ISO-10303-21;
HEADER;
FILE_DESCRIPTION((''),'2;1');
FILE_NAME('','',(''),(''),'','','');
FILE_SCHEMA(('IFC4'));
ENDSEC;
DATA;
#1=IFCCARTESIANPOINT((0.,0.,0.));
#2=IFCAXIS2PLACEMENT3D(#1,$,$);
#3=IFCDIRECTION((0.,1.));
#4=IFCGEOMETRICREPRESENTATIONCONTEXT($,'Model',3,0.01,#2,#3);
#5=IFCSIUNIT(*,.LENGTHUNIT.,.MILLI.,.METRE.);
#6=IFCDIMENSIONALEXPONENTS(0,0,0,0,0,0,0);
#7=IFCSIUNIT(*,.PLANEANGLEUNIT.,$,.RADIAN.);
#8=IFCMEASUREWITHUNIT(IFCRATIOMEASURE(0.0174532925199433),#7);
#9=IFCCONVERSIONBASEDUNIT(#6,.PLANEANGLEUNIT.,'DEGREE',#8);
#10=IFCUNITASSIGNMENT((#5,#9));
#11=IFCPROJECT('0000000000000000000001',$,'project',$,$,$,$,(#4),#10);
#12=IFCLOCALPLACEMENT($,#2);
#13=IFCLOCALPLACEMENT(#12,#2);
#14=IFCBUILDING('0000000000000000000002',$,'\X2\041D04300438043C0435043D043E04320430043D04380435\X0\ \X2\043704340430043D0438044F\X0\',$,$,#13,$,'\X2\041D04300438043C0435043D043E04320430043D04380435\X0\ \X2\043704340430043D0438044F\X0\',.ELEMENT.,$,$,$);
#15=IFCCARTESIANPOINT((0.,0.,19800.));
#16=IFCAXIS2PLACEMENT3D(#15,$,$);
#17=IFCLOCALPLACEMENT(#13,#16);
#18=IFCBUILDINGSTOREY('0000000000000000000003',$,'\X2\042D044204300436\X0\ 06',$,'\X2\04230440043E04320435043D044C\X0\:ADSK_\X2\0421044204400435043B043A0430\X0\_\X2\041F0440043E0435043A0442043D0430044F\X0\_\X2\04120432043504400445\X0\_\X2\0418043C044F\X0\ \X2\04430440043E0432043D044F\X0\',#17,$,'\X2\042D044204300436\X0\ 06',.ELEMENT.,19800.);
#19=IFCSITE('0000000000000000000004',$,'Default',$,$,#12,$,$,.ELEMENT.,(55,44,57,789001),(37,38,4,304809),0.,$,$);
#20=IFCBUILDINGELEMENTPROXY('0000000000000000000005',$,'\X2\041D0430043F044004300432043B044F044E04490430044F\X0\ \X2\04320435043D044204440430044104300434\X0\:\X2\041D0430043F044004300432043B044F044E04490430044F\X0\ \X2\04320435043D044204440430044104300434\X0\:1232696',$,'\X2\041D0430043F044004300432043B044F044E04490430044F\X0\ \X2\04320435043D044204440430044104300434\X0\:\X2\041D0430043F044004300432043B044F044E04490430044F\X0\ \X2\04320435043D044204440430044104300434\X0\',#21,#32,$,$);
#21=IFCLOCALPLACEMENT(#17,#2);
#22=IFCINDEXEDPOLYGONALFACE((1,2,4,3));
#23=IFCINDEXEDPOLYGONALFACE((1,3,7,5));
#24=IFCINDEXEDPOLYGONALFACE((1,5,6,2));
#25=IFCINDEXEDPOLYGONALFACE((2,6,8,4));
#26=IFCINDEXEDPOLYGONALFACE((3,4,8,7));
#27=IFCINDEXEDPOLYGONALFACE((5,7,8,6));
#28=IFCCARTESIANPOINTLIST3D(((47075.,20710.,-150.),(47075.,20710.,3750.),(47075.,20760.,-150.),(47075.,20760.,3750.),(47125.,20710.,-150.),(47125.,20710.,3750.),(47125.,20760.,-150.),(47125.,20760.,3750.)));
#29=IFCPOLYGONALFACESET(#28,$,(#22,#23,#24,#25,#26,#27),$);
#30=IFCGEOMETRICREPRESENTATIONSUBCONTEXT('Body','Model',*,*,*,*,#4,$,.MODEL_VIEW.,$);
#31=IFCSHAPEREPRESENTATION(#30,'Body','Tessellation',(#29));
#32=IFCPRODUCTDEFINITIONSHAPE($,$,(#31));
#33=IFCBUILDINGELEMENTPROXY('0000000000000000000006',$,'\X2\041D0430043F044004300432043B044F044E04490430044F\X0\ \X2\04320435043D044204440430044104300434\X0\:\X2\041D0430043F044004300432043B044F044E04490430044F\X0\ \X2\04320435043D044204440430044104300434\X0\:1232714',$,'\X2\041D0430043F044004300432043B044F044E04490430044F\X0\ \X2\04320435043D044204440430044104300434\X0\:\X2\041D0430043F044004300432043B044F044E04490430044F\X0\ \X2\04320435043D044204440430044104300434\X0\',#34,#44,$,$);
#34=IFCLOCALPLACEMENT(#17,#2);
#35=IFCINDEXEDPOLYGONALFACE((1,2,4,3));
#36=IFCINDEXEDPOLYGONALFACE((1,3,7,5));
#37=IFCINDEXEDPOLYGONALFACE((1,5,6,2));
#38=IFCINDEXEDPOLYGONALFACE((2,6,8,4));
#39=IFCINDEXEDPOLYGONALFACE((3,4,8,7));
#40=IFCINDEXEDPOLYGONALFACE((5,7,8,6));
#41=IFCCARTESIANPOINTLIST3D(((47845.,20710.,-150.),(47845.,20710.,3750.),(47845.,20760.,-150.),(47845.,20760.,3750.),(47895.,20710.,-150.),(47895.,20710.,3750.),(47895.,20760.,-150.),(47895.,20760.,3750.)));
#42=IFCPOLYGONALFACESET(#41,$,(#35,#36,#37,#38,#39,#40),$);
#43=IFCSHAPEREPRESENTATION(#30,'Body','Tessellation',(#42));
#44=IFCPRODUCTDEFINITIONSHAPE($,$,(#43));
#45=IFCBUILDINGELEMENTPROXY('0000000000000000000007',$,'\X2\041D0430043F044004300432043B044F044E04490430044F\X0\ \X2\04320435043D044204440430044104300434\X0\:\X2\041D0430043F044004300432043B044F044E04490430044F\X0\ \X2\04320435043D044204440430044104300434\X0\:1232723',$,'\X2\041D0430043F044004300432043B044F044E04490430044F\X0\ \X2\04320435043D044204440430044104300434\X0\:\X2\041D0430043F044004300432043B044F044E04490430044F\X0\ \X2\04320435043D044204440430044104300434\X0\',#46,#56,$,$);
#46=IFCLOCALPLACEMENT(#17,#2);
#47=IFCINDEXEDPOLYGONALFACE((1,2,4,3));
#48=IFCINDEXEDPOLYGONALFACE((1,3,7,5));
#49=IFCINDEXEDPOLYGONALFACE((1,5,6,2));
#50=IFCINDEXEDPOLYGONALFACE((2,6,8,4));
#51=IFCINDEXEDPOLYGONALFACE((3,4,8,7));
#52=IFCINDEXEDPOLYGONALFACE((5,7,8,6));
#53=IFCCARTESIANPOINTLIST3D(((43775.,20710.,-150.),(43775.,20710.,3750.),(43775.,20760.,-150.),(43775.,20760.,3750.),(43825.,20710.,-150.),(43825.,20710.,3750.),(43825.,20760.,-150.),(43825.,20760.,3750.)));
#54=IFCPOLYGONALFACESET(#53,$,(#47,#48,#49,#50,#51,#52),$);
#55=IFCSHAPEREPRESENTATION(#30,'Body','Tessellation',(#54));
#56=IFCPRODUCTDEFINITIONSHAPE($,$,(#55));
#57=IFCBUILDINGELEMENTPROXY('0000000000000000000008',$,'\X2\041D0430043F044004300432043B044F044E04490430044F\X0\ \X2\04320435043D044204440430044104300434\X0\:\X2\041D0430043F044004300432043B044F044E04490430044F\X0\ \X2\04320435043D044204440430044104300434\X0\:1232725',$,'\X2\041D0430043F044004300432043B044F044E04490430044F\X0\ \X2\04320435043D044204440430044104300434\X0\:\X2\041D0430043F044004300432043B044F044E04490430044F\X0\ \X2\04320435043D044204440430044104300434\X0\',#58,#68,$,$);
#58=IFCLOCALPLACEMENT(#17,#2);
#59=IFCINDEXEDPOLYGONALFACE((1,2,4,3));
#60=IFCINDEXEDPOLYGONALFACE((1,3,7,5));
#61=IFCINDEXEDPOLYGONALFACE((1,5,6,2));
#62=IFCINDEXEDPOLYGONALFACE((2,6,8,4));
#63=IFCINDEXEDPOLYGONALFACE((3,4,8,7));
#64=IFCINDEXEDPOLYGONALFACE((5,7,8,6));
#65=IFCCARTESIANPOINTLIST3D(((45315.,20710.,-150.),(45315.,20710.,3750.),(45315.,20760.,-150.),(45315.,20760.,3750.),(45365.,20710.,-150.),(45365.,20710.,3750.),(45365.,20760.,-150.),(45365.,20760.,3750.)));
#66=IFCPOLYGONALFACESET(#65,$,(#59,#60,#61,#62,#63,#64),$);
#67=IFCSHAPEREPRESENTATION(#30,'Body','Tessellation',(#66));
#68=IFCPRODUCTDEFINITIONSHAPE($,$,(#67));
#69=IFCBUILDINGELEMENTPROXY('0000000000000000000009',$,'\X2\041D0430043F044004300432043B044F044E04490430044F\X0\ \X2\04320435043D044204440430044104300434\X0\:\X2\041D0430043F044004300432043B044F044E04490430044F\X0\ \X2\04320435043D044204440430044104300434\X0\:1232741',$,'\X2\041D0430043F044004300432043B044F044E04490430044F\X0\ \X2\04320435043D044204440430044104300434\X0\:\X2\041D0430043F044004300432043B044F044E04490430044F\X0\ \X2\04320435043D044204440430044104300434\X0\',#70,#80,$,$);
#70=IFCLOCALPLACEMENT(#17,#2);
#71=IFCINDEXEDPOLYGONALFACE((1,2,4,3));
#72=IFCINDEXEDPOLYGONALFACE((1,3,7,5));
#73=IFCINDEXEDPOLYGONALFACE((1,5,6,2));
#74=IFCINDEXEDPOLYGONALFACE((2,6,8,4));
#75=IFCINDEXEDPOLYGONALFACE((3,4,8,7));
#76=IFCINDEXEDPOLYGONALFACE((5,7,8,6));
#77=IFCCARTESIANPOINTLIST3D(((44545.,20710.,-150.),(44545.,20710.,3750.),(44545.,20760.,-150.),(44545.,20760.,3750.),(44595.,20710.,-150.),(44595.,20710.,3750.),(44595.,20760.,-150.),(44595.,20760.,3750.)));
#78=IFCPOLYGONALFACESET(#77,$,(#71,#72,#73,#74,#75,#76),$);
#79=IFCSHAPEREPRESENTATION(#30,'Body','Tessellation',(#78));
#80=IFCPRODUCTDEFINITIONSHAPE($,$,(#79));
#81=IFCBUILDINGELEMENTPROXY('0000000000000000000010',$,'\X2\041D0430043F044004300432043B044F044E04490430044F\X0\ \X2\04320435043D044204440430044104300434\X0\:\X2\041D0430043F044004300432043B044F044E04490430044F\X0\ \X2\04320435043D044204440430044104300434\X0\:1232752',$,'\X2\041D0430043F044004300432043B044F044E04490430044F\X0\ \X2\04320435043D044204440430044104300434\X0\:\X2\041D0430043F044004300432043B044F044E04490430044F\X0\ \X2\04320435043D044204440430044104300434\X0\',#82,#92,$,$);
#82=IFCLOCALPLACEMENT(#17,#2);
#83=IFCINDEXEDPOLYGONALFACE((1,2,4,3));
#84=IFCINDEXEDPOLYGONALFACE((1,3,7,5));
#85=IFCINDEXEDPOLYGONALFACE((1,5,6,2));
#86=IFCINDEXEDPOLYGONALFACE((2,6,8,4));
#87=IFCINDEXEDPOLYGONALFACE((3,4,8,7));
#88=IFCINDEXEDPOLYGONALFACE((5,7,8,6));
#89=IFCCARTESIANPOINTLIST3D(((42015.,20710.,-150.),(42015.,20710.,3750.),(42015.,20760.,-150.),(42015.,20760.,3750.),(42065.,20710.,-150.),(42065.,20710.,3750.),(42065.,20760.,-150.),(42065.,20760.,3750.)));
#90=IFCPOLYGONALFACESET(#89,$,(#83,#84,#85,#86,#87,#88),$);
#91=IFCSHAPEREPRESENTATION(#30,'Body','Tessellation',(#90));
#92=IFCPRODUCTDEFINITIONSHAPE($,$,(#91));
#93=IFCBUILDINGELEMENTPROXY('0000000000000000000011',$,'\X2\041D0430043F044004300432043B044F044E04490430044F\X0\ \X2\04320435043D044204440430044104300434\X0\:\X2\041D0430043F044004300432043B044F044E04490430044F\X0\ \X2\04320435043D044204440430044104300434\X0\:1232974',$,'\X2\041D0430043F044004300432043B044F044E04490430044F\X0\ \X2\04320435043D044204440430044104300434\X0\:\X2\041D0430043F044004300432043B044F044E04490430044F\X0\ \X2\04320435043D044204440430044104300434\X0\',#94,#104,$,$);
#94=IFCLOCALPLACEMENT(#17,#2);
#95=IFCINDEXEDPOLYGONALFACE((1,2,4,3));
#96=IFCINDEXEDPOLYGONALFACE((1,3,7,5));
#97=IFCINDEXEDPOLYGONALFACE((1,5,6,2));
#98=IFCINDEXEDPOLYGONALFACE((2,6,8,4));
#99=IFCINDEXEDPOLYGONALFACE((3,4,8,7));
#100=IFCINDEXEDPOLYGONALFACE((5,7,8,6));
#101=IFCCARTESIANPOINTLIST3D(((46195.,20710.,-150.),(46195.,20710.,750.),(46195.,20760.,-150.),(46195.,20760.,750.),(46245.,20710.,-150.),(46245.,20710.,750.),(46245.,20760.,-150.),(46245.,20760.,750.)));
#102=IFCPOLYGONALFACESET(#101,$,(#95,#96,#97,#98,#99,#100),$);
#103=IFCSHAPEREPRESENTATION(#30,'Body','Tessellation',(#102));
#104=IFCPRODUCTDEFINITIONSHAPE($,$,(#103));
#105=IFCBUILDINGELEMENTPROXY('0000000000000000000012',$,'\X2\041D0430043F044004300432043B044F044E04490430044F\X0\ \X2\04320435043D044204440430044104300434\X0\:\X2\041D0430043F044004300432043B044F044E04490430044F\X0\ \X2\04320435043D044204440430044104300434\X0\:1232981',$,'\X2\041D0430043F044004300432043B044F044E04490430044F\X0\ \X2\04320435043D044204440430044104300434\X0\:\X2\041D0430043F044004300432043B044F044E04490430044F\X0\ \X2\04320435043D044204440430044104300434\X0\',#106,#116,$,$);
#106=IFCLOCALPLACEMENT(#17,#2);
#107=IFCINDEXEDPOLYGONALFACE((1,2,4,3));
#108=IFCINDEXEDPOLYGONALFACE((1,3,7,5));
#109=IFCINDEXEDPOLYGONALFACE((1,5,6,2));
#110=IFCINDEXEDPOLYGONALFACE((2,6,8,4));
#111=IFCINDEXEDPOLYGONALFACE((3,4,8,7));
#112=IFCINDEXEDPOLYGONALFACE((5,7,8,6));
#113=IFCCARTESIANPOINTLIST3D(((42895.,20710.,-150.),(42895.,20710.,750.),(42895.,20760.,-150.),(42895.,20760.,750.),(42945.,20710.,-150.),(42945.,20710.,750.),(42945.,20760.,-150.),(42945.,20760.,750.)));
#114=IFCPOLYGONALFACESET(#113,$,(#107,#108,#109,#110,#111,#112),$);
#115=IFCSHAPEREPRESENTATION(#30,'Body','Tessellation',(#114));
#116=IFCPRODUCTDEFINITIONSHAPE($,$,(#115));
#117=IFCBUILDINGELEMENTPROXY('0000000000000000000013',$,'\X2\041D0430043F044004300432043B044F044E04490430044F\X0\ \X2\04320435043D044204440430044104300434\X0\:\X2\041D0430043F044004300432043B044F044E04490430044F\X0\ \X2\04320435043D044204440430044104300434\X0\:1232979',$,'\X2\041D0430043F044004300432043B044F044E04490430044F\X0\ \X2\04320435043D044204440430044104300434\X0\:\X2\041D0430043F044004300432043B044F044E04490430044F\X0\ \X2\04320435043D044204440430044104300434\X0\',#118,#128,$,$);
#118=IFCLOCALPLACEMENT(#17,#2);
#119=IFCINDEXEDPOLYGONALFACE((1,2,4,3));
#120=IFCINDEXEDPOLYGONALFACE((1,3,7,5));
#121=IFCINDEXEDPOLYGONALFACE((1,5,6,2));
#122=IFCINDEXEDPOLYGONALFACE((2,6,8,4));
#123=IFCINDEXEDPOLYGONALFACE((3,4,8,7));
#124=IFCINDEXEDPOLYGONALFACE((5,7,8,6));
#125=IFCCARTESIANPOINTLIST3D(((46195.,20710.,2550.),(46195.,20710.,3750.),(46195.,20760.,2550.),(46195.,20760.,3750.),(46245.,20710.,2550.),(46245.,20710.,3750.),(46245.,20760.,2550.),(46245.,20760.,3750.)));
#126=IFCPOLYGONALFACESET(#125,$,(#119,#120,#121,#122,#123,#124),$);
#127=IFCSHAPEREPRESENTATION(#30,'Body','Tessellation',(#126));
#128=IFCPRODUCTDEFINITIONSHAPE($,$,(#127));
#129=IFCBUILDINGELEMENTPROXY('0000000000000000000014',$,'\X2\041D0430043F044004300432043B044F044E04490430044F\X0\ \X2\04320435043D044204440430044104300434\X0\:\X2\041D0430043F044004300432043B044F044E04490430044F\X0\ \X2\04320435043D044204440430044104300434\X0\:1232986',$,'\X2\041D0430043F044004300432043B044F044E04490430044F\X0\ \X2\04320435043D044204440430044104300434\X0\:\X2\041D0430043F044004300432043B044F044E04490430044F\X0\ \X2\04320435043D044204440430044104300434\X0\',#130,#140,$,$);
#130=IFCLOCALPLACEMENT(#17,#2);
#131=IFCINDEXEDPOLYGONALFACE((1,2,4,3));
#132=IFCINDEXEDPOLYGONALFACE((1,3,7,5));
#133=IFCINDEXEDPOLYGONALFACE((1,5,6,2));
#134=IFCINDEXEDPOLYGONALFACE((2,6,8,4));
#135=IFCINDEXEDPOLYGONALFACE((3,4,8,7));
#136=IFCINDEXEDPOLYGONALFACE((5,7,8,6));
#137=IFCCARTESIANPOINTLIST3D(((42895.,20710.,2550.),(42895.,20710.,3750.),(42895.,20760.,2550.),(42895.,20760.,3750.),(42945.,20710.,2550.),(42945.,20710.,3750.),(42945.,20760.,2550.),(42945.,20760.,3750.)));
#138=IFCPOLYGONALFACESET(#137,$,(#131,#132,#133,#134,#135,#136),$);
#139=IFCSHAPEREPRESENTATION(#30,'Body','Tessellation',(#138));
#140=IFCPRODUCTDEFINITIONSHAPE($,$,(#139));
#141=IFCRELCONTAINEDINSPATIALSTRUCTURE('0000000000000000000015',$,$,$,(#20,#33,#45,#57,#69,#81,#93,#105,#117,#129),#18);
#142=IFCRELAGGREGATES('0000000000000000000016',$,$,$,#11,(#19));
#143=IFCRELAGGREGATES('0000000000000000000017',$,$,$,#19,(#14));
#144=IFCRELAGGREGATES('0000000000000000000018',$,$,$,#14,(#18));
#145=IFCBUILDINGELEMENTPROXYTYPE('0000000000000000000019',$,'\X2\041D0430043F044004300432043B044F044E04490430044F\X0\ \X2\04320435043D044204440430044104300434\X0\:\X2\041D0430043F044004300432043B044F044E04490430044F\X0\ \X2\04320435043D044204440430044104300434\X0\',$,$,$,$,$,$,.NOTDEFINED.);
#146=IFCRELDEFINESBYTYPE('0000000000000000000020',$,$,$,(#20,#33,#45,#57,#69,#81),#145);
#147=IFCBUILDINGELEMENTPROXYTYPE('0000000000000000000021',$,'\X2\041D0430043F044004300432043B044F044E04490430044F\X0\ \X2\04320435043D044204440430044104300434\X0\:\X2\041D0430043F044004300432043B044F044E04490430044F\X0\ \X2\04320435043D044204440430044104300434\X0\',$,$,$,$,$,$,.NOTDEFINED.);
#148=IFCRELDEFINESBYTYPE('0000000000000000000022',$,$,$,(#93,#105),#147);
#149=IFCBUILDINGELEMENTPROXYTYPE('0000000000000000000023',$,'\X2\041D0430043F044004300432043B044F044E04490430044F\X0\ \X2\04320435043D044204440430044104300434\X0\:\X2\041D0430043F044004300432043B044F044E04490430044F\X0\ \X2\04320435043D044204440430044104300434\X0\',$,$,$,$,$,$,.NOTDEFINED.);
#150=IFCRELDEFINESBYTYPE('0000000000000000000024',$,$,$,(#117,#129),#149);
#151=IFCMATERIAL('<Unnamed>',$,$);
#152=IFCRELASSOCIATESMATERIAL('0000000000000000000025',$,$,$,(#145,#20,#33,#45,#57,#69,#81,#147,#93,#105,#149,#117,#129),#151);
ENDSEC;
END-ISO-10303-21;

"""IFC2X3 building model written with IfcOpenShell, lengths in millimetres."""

from ifc_helpers import new_model, entity, si_unit, converted_unit, direction, frame, origin, origin_2d_with_axis, place, context, subcontext, project, spatial, rectangle, extrude, source, transform, mapped, material, type_object, type_shapes, element, save


model = new_model("IFC2X3")

# Units and contexts
model_context = context("Model", 3, precision=0.01, world=origin(), true_north=direction((0.0, 1.0)))
body_context = subcontext(model_context, "Body", "Model", "MODEL_VIEW")
ifc_project = project(units=[si_unit("LENGTHUNIT", "METRE", prefix="MILLI"), converted_unit("PLANEANGLEUNIT", "DEGREE", entity("IfcRatioMeasure", 0.0174532925199433), si_unit("PLANEANGLEUNIT", "RADIAN"), dimensions=[0, 0, 0, 0, 0, 0, 0])], contexts=[model_context])

# Site, building, storey
site_placement = place(None, origin())
site = spatial("IfcSite", under=ifc_project, at=site_placement, Name="Default", CompositionType="ELEMENT", RefLatitude=(55, 44, 57, 789001), RefLongitude=(37, 38, 4, 304809), RefElevation=0.0)
building_placement = place(site_placement, origin())
building = spatial("IfcBuilding", under=site, at=building_placement, Name="Наименование здания", LongName="Наименование здания", CompositionType="ELEMENT")
storey_placement = place(building_placement, frame((0.0, 0.0, 19800.0)))
storey = spatial("IfcBuildingStorey", under=building, at=storey_placement, Name="Этаж 06", ObjectType="Уровень:ADSK_Стрелка_Проектная_Вверх_Имя уровня", LongName="Этаж 06", CompositionType="ELEMENT", Elevation=19800.0)

# Building element proxies
ifc_material_1 = material(Name="<Unnamed>")
building_element_proxy_type_1 = type_object("IfcBuildingElementProxyType", Name="Направляющая вентфасад:Направляющая вентфасад", PredefinedType="NOTDEFINED", material=ifc_material_1)
shared_shape_1 = source(origin(), body_context, "Body", "SweptSolid", [
    extrude(rectangle(XDim=50.0, YDim=50.0, at=origin_2d_with_axis()), frame((25.0, -25.0, 0.0), z_axis=(0.0, 0.0, 1.0), x_axis=(-1.0, 0.0, 0.0)), (0.0, 0.0, 1.0), 3900.0),
])
type_shapes(building_element_proxy_type_1, [shared_shape_1])
for number, where, z_axis, x_axis, name in (
    (1, (47125.0, 20710.0, -150.0), (0.0, 0.0, 1.0), (-1.0, 0.0, 0.0), "Направляющая вентфасад:Направляющая вентфасад:1232696"),
    (2, (47895.0, 20710.0, -150.0), (0.0, 0.0, 1.0), (-1.0, 0.0, 0.0), "Направляющая вентфасад:Направляющая вентфасад:1232714"),
    (3, (43825.0, 20710.0, -150.0), (0.0, 0.0, 1.0), (-1.0, 0.0, 0.0), "Направляющая вентфасад:Направляющая вентфасад:1232723"),
    (4, (45365.0, 20710.0, -150.0), (0.0, 0.0, 1.0), (-1.0, 0.0, 0.0), "Направляющая вентфасад:Направляющая вентфасад:1232725"),
    (5, (44595.0, 20710.0, -150.0), (0.0, 0.0, 1.0), (-1.0, 0.0, 0.0), "Направляющая вентфасад:Направляющая вентфасад:1232741"),
    (6, (42065.0, 20710.0, -150.0), (0.0, 0.0, 1.0), (-1.0, 0.0, 0.0), "Направляющая вентфасад:Направляющая вентфасад:1232752"),
):
    element("IfcBuildingElementProxy", number, at=place(storey_placement, frame(where, z_axis=z_axis, x_axis=x_axis)), inside=storey, type_object=building_element_proxy_type_1, material=ifc_material_1, Name=name, ObjectType="Направляющая вентфасад:Направляющая вентфасад", context=body_context, shape_type="MappedRepresentation", body=[
        mapped(shared_shape_1, transform((0.0, 0.0, 0.0), scale=1.0)),
    ])
building_element_proxy_type_2 = type_object("IfcBuildingElementProxyType", Name="Направляющая вентфасад:Направляющая вентфасад", PredefinedType="NOTDEFINED", material=ifc_material_1)
shared_shape_2 = source(origin(), body_context, "Body", "SweptSolid", [
    extrude(rectangle(XDim=50.0, YDim=50.0, at=origin_2d_with_axis()), frame((25.0, -25.0, 0.0), z_axis=(0.0, 0.0, 1.0), x_axis=(-1.0, 0.0, 0.0)), (0.0, 0.0, 1.0), 900.0),
])
type_shapes(building_element_proxy_type_2, [shared_shape_2])
for number, where, z_axis, x_axis, name in (
    (7, (46245.0, 20710.0, -150.0), (0.0, 0.0, 1.0), (-1.0, 0.0, 0.0), "Направляющая вентфасад:Направляющая вентфасад:1232974"),
    (8, (42945.0, 20710.0, -150.0), (0.0, 0.0, 1.0), (-1.0, 0.0, 0.0), "Направляющая вентфасад:Направляющая вентфасад:1232981"),
):
    element("IfcBuildingElementProxy", number, at=place(storey_placement, frame(where, z_axis=z_axis, x_axis=x_axis)), inside=storey, type_object=building_element_proxy_type_2, material=ifc_material_1, Name=name, ObjectType="Направляющая вентфасад:Направляющая вентфасад", context=body_context, shape_type="MappedRepresentation", body=[
        mapped(shared_shape_2, transform((0.0, 0.0, 0.0), scale=1.0)),
    ])
building_element_proxy_type_3 = type_object("IfcBuildingElementProxyType", Name="Направляющая вентфасад:Направляющая вентфасад", PredefinedType="NOTDEFINED", material=ifc_material_1)
shared_shape_3 = source(origin(), body_context, "Body", "SweptSolid", [
    extrude(rectangle(XDim=50.0, YDim=50.0, at=origin_2d_with_axis()), frame((25.0, -25.0, 0.0), z_axis=(0.0, 0.0, 1.0), x_axis=(-1.0, 0.0, 0.0)), (0.0, 0.0, 1.0), 1200.0),
])
type_shapes(building_element_proxy_type_3, [shared_shape_3])
for number, where, z_axis, x_axis, name in (
    (9, (46245.0, 20710.0, 2550.0), (0.0, 0.0, 1.0), (-1.0, 0.0, 0.0), "Направляющая вентфасад:Направляющая вентфасад:1232979"),
    (10, (42945.0, 20710.0, 2550.0), (0.0, 0.0, 1.0), (-1.0, 0.0, 0.0), "Направляющая вентфасад:Направляющая вентфасад:1232986"),
):
    element("IfcBuildingElementProxy", number, at=place(storey_placement, frame(where, z_axis=z_axis, x_axis=x_axis)), inside=storey, type_object=building_element_proxy_type_3, material=ifc_material_1, Name=name, ObjectType="Направляющая вентфасад:Направляющая вентфасад", context=body_context, shape_type="MappedRepresentation", body=[
        mapped(shared_shape_3, transform((0.0, 0.0, 0.0), scale=1.0)),
    ])

save(model, "model.ifc")
